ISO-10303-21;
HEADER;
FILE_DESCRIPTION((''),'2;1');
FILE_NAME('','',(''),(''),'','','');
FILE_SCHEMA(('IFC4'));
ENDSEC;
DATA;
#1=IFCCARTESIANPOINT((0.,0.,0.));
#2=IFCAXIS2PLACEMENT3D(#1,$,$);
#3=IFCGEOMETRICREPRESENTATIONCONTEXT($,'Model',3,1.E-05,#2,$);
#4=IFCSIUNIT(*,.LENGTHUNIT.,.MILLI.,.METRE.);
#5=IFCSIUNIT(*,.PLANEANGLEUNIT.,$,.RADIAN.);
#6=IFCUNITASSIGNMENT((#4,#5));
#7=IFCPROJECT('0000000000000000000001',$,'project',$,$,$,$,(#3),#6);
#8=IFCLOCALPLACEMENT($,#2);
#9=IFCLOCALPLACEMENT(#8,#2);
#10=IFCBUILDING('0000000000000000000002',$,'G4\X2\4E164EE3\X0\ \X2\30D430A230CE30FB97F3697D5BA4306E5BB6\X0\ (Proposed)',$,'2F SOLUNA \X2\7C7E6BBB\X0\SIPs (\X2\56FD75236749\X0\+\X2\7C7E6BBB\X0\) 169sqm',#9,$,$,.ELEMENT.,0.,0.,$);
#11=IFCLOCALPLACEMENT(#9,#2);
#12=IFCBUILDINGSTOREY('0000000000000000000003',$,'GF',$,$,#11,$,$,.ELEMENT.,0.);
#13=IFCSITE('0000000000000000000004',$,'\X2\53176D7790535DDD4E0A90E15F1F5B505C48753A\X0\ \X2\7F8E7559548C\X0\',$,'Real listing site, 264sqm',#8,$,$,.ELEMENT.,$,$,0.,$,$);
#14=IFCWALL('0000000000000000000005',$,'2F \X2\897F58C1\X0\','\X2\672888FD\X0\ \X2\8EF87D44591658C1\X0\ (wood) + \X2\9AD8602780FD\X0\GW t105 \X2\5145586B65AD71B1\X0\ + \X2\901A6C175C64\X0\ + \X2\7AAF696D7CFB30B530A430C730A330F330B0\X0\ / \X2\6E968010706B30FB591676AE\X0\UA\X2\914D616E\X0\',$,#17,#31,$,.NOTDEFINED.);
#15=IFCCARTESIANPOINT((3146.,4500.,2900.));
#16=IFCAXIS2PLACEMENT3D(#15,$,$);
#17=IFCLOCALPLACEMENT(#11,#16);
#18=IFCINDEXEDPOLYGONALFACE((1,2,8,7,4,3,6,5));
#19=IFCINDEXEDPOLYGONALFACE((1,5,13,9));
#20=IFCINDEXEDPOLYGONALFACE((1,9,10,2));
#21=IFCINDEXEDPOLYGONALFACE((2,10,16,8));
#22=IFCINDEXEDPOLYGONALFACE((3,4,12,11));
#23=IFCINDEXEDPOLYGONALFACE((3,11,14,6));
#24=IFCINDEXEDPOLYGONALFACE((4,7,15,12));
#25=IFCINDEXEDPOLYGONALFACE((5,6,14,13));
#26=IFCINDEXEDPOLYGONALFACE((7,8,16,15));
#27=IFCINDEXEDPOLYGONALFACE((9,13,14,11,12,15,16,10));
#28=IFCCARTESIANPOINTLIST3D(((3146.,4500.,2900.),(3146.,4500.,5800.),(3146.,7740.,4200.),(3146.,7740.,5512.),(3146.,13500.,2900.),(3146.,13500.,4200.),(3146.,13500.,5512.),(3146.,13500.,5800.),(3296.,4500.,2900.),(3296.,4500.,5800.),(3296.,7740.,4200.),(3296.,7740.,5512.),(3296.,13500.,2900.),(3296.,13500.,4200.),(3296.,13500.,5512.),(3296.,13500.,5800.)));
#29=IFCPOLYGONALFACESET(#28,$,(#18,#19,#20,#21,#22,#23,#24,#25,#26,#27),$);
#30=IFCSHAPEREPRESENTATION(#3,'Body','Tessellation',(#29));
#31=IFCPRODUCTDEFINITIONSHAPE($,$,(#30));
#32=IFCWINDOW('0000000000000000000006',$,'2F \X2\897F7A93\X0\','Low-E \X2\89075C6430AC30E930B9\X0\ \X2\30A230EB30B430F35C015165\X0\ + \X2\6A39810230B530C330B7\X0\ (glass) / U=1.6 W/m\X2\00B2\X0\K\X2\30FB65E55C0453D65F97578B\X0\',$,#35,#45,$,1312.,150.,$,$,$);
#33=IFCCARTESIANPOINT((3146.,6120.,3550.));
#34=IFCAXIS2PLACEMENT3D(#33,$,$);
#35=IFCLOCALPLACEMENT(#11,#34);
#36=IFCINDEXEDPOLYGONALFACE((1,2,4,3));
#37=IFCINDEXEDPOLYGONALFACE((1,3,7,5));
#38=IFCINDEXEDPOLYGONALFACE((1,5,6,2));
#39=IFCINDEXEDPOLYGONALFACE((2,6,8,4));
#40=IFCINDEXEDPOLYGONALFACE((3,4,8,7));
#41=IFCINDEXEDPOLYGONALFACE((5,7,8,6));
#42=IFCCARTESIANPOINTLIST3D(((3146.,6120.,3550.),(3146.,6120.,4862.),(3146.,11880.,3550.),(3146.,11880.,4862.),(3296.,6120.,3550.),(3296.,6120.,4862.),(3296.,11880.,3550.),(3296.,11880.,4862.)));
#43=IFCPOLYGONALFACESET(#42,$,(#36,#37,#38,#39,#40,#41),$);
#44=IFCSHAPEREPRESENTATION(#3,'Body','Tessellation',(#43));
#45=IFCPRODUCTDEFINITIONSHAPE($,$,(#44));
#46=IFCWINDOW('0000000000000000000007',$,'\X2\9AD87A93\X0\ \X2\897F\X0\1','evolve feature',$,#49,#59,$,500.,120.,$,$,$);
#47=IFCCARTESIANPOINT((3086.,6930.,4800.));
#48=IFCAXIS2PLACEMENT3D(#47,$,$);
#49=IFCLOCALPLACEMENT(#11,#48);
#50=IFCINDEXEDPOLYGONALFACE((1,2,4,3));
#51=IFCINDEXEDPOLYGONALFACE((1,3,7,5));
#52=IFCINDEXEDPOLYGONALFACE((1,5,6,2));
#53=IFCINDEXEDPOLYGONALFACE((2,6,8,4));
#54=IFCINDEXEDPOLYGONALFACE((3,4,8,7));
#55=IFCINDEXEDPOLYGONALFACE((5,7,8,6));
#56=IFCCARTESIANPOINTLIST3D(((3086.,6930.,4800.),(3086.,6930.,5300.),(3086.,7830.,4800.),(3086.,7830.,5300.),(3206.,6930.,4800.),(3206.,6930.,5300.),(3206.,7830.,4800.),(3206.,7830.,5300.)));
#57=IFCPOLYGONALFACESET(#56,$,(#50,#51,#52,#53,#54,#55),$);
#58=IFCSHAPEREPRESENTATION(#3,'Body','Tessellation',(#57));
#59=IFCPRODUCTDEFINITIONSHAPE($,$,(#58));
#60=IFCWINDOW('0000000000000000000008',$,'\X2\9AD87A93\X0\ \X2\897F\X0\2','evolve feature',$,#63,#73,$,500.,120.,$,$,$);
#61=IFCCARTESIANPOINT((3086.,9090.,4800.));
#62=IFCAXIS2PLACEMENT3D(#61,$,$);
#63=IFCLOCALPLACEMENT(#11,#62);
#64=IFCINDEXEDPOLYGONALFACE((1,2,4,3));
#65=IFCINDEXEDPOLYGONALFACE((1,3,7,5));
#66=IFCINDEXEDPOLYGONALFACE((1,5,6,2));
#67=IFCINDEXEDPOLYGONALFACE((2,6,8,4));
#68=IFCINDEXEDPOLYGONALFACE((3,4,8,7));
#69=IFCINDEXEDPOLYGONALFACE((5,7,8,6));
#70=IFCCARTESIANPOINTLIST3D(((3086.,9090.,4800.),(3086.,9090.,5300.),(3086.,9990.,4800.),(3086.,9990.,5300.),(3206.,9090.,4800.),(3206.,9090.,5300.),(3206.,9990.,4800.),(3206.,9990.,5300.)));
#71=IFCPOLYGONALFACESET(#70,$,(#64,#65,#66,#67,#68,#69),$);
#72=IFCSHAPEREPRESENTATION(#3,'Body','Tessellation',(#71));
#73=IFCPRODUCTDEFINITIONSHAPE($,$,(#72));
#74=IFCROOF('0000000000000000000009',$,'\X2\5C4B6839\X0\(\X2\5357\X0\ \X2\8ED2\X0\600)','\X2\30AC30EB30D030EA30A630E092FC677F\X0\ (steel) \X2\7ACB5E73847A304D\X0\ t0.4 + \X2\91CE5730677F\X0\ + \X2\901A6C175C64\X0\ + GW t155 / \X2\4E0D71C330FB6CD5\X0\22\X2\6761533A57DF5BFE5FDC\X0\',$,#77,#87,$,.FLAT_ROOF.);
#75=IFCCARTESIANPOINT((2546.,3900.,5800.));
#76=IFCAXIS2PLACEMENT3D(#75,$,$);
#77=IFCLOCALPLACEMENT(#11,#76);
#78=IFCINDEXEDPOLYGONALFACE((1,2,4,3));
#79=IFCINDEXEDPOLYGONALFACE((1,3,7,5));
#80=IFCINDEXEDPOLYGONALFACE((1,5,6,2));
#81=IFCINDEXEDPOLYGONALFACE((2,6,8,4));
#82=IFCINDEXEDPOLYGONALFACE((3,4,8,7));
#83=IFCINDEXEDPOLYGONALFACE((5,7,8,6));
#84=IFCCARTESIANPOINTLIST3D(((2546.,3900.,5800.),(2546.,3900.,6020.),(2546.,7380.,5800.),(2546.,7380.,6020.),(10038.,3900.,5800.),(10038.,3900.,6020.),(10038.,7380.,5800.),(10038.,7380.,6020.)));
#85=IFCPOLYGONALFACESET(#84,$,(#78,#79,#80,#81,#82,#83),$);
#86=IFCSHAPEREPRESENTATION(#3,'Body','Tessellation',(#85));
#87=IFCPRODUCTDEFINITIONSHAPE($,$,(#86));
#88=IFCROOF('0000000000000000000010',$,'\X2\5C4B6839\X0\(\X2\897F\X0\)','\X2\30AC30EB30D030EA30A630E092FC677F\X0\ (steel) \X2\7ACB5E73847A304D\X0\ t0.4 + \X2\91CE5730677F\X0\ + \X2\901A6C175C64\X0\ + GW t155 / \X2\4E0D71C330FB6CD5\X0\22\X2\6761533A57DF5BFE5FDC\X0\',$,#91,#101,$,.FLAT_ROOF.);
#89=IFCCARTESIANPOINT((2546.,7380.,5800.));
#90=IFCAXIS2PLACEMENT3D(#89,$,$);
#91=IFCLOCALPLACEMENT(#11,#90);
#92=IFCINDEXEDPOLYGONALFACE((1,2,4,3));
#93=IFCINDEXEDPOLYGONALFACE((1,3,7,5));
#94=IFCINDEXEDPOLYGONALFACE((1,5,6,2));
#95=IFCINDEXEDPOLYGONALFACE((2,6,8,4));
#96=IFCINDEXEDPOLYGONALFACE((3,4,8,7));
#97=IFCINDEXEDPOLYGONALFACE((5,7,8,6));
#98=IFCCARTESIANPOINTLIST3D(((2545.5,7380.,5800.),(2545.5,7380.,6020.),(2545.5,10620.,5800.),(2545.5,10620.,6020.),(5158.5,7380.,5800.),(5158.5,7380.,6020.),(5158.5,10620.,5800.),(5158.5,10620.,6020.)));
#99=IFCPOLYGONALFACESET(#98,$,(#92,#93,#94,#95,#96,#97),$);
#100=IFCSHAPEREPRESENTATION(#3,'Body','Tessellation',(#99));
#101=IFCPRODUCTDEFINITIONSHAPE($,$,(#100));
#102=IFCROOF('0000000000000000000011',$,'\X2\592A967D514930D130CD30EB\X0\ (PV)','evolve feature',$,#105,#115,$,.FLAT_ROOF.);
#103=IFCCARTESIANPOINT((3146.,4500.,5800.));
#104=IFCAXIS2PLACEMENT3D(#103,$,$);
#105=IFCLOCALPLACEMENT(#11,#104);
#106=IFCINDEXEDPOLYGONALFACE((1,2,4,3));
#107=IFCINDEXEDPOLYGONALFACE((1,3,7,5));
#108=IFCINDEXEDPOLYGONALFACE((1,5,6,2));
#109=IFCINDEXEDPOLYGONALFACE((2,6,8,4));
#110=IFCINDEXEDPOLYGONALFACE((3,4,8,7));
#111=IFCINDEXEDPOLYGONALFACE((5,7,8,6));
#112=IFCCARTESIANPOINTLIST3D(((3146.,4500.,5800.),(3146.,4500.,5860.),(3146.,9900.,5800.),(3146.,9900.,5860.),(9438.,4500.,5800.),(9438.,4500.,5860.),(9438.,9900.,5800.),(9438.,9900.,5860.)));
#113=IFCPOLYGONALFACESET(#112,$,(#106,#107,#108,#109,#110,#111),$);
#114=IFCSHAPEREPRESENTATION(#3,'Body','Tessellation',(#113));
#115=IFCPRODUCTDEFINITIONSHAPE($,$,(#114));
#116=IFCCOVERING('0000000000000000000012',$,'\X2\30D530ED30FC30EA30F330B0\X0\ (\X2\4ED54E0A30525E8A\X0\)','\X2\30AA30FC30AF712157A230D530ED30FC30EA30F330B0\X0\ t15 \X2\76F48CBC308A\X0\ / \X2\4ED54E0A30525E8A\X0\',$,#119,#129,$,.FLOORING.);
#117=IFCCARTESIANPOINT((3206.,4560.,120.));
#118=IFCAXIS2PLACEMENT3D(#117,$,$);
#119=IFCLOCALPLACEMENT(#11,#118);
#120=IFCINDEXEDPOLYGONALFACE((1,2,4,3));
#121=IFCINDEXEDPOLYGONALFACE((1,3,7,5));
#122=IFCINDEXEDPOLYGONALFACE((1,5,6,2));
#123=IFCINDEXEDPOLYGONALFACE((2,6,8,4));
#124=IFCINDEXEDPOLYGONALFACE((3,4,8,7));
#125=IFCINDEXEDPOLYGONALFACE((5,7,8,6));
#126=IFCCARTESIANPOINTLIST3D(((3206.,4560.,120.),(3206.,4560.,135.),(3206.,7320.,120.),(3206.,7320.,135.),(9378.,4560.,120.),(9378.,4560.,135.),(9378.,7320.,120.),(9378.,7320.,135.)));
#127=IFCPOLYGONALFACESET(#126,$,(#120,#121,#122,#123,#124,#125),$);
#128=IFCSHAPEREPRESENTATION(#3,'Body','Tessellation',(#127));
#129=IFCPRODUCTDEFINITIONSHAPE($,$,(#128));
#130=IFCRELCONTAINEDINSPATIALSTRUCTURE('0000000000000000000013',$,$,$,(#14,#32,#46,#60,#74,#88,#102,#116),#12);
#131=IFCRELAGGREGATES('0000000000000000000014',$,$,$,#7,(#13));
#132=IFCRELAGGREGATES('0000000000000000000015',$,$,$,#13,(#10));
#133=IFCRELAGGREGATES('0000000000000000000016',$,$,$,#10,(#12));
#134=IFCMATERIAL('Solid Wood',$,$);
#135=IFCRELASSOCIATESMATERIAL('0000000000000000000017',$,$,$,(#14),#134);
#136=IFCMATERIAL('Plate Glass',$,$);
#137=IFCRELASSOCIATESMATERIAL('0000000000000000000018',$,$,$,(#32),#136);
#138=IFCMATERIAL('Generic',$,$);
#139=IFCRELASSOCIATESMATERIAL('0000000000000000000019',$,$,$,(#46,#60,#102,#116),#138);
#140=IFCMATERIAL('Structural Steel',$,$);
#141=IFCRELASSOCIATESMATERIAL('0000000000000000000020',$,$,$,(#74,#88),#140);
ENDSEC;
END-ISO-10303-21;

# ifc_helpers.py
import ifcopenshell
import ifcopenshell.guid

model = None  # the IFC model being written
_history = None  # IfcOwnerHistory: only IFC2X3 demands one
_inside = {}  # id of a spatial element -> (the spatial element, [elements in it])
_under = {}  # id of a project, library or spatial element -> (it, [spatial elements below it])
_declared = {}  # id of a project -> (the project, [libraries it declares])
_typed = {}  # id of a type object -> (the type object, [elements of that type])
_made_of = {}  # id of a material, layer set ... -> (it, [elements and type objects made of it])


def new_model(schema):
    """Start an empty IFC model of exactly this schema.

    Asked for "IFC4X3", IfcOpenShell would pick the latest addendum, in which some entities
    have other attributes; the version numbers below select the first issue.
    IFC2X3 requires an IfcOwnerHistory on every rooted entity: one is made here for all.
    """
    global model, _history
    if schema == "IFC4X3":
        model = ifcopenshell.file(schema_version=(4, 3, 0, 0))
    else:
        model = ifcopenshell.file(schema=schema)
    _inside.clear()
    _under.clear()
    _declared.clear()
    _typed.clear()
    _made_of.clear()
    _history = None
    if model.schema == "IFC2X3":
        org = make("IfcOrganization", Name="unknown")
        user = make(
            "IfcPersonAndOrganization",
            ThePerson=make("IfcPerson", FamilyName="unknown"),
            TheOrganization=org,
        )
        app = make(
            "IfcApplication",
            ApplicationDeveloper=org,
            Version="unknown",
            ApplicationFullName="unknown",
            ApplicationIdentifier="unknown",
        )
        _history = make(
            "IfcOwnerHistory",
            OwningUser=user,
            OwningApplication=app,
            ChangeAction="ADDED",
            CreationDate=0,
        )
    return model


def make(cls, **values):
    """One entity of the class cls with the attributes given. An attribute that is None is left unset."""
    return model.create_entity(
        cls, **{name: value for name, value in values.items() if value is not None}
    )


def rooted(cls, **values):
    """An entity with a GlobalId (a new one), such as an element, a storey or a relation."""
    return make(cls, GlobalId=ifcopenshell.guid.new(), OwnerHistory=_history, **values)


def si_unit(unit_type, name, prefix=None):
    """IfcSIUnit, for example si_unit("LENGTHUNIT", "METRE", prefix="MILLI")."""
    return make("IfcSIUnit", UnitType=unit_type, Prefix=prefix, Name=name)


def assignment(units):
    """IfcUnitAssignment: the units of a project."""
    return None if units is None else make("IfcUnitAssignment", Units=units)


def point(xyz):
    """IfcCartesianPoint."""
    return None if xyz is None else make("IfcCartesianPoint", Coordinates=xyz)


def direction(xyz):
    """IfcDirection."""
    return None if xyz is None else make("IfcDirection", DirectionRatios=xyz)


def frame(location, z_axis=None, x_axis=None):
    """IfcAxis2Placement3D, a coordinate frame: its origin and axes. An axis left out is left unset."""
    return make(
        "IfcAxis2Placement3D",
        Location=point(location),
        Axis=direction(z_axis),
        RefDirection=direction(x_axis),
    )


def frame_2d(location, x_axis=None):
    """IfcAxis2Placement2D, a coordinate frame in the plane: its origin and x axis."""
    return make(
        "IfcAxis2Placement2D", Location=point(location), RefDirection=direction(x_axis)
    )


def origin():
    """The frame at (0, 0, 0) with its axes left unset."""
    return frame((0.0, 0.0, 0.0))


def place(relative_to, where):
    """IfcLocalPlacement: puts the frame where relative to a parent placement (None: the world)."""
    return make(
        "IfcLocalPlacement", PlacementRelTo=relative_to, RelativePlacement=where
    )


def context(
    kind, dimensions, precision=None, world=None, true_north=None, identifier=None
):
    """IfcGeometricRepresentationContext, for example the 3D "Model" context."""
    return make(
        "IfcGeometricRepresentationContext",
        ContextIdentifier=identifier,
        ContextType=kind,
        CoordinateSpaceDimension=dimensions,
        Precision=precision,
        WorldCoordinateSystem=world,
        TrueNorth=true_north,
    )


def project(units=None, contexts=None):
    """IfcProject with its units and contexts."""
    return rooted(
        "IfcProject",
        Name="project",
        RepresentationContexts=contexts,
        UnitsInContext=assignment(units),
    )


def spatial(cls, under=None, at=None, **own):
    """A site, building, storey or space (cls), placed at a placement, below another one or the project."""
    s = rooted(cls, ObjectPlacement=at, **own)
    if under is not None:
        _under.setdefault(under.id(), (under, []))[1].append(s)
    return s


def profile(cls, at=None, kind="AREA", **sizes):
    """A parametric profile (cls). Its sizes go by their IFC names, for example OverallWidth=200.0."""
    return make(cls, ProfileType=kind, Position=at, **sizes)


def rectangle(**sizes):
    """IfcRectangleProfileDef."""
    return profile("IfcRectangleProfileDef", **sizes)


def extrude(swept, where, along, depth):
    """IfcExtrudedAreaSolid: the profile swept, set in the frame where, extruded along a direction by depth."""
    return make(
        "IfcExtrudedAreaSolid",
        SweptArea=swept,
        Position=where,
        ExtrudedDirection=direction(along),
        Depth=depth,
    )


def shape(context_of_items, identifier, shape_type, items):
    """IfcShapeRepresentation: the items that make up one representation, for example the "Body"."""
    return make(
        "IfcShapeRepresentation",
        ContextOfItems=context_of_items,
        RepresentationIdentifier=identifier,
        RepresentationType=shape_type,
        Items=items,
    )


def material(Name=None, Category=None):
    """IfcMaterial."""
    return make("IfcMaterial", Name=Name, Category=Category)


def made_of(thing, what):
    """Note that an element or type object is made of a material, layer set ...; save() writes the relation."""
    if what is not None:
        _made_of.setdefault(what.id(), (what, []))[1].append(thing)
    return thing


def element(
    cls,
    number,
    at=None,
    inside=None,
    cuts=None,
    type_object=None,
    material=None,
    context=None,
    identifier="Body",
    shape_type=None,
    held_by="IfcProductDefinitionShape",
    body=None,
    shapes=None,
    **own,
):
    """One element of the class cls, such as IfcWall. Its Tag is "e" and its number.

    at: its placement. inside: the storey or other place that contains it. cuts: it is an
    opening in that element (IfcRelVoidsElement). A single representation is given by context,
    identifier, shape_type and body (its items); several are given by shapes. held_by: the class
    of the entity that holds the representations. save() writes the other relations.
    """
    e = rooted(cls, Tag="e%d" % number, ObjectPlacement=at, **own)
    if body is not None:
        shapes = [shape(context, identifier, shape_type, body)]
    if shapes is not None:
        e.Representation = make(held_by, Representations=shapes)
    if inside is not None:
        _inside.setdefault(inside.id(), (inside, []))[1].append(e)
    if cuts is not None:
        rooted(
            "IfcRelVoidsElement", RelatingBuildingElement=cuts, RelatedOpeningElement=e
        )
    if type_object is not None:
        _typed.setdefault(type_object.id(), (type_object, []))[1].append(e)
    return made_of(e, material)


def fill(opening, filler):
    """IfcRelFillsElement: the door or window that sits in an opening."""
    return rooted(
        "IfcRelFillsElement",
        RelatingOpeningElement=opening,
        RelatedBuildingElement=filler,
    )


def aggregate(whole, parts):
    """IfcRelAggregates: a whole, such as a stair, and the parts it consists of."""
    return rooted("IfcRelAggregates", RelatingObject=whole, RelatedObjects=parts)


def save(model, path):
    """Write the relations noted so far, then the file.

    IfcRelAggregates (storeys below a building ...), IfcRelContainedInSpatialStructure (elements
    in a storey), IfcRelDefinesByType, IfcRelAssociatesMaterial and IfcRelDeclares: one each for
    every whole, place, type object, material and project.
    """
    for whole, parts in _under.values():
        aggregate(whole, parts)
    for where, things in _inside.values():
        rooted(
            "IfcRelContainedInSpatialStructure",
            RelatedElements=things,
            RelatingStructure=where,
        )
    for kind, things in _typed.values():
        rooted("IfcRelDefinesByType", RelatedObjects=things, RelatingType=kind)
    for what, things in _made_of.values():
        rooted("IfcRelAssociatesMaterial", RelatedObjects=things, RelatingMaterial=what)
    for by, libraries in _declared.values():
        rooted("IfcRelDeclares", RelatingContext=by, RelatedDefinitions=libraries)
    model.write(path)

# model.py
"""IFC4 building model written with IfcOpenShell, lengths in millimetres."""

from ifc_helpers import new_model, si_unit, frame, frame_2d, origin, place, context, project, spatial, rectangle, extrude, material, element, fill, save


model = new_model("IFC4")

# Units and contexts
model_context = context("Model", 3, precision=1e-05, world=origin())
ifc_project = project(units=[si_unit("LENGTHUNIT", "METRE", prefix="MILLI"), si_unit("PLANEANGLEUNIT", "RADIAN")], contexts=[model_context])

# Site, building, storey
site_placement = place(None, origin())
site = spatial("IfcSite", under=ifc_project, at=site_placement, Name="北海道川上郡弟子屈町 美留和", ObjectType="Real listing site, 264sqm", CompositionType="ELEMENT", RefElevation=0.0)
building_placement = place(site_placement, origin())
building = spatial("IfcBuilding", under=site, at=building_placement, Name="G4世代 ピアノ・音楽室の家 (Proposed)", ObjectType="2F SOLUNA 籾殻SIPs (国産杉+籾殻) 169sqm", CompositionType="ELEMENT", ElevationOfRefHeight=0.0, ElevationOfTerrain=0.0)
storey_placement = place(building_placement, origin())
storey = spatial("IfcBuildingStorey", under=building, at=storey_placement, Name="GF", CompositionType="ELEMENT", Elevation=0.0)

# Shared definitions
ifc_material_1 = material(Name="Solid Wood")
ifc_material_2 = material(Name="Generic")

# Shared definitions
ifc_material_3 = material(Name="Plate Glass")

# Wall, openings, windows
wall_1_placement = place(storey_placement, frame((3146.0, 4500.0, 2900.0)))
wall_1 = element("IfcWall", 1, at=wall_1_placement, inside=storey, material=ifc_material_1, Name="2F 西壁", Description="木製 軸組外壁 (wood) + 高性能GW t105 充填断熱 + 通気層 + 窯業系サイディング / 準耐火・外皮UA配慮", PredefinedType="NOTDEFINED", context=model_context, shape_type="SweptSolid", body=[
    extrude(rectangle(XDim=150.0, YDim=9000.0, at=frame_2d((75.0, 4500.0))), frame((3146.0, 4500.0, 2900.0)), (0.0, 0.0, 1.0), 2900.0),
])
opening_1_placement = place(storey_placement, frame((3146.0, 6120.0, 3550.0)))
opening_1 = element("IfcOpeningElement", 2, at=opening_1_placement, cuts=wall_1, PredefinedType="NOTDEFINED", context=model_context, shape_type="SweptSolid", body=[
    extrude(rectangle(XDim=150.0, YDim=5760.0, at=frame_2d((75.0, 2880.0))), frame((3146.0, 6120.0, 3550.0)), (0.0, 0.0, 1.0), 1312.0),
])
opening_2_placement = place(storey_placement, frame((3086.0, 6930.0, 4800.0)))
opening_2 = element("IfcOpeningElement", 3, at=opening_2_placement, cuts=wall_1, PredefinedType="NOTDEFINED", context=model_context, shape_type="SweptSolid", body=[
    extrude(rectangle(XDim=120.0, YDim=900.0, at=frame_2d((60.0, 450.0))), frame((3086.0, 6930.0, 4800.0)), (0.0, 0.0, 1.0), 500.0),
])
opening_3_placement = place(storey_placement, frame((3086.0, 9090.0, 4800.0)))
opening_3 = element("IfcOpeningElement", 4, at=opening_3_placement, cuts=wall_1, PredefinedType="NOTDEFINED", context=model_context, shape_type="SweptSolid", body=[
    extrude(rectangle(XDim=120.0, YDim=900.0, at=frame_2d((60.0, 450.0))), frame((3086.0, 9090.0, 4800.0)), (0.0, 0.0, 1.0), 500.0),
])
window_1_placement = place(storey_placement, frame((3146.0, 6120.0, 3550.0)))
window_1 = element("IfcWindow", 5, at=window_1_placement, inside=storey, material=ifc_material_3, Name="2F 西窓", Description="Low-E 複層ガラス アルゴン封入 + 樹脂サッシ (glass) / U=1.6 W/m²K・日射取得型", OverallHeight=1312.0, OverallWidth=150.0, context=model_context, shape_type="SweptSolid", body=[
    extrude(rectangle(XDim=150.0, YDim=5760.0, at=frame_2d((75.0, 2880.0))), frame((3146.0, 6120.0, 3550.0)), (0.0, 0.0, 1.0), 1312.0),
])
fill(opening_1, window_1)
window_2_placement = place(storey_placement, frame((3086.0, 6930.0, 4800.0)))
window_2 = element("IfcWindow", 6, at=window_2_placement, inside=storey, material=ifc_material_2, Name="高窓 西1", Description="evolve feature", OverallHeight=500.0, OverallWidth=120.0, context=model_context, shape_type="SweptSolid", body=[
    extrude(rectangle(XDim=120.0, YDim=900.0, at=frame_2d((60.0, 450.0))), frame((3086.0, 6930.0, 4800.0)), (0.0, 0.0, 1.0), 500.0),
])
fill(opening_2, window_2)
window_3_placement = place(storey_placement, frame((3086.0, 9090.0, 4800.0)))
window_3 = element("IfcWindow", 7, at=window_3_placement, inside=storey, material=ifc_material_2, Name="高窓 西2", Description="evolve feature", OverallHeight=500.0, OverallWidth=120.0, context=model_context, shape_type="SweptSolid", body=[
    extrude(rectangle(XDim=120.0, YDim=900.0, at=frame_2d((60.0, 450.0))), frame((3086.0, 9090.0, 4800.0)), (0.0, 0.0, 1.0), 500.0),
])
fill(opening_3, window_3)

# Roofs
ifc_material_4 = material(Name="Structural Steel")
roof_1_placement = place(storey_placement, frame((2546.0, 3900.0, 5800.0)))
element("IfcRoof", 8, at=roof_1_placement, inside=storey, material=ifc_material_4, Name="屋根(南 軒600)", Description="ガルバリウム鋼板 (steel) 立平葺き t0.4 + 野地板 + 通気層 + GW t155 / 不燃・法22条区域対応", PredefinedType="FLAT_ROOF", context=model_context, shape_type="SweptSolid", body=[
    extrude(rectangle(XDim=7492.0, YDim=3480.0, at=frame_2d((3746.0, 1740.0))), frame((2546.0, 3900.0, 5800.0)), (0.0, 0.0, 1.0), 220.0),
])
roof_2_placement = place(storey_placement, frame((2546.0, 7380.0, 5800.0)))
element("IfcRoof", 9, at=roof_2_placement, inside=storey, material=ifc_material_4, Name="屋根(西)", Description="ガルバリウム鋼板 (steel) 立平葺き t0.4 + 野地板 + 通気層 + GW t155 / 不燃・法22条区域対応", PredefinedType="FLAT_ROOF", context=model_context, shape_type="SweptSolid", body=[
    extrude(rectangle(XDim=2613.0, YDim=3240.0, at=frame_2d((1306.0, 1620.0))), frame((2546.0, 7380.0, 5800.0)), (0.0, 0.0, 1.0), 220.0),
])
roof_3_placement = place(storey_placement, frame((3146.0, 4500.0, 5800.0)))
element("IfcRoof", 10, at=roof_3_placement, inside=storey, material=ifc_material_2, Name="太陽光パネル (PV)", Description="evolve feature", PredefinedType="FLAT_ROOF", context=model_context, shape_type="SweptSolid", body=[
    extrude(rectangle(XDim=6292.0, YDim=5400.0, at=frame_2d((3146.0, 2700.0))), frame((3146.0, 4500.0, 5800.0)), (0.0, 0.0, 1.0), 60.0),
])

# Covering
covering_placement = place(storey_placement, frame((3206.0, 4560.0, 120.0)))
element("IfcCovering", 11, at=covering_placement, inside=storey, material=ifc_material_2, Name="フローリング (仕上げ床)", Description="オーク無垢フローリング t15 直貼り / 仕上げ床", PredefinedType="FLOORING", context=model_context, shape_type="SweptSolid", body=[
    extrude(rectangle(XDim=6172.0, YDim=2760.0, at=frame_2d((3086.0, 1380.0))), frame((3206.0, 4560.0, 120.0)), (0.0, 0.0, 1.0), 15.0),
])

save(model, "model.ifc")
